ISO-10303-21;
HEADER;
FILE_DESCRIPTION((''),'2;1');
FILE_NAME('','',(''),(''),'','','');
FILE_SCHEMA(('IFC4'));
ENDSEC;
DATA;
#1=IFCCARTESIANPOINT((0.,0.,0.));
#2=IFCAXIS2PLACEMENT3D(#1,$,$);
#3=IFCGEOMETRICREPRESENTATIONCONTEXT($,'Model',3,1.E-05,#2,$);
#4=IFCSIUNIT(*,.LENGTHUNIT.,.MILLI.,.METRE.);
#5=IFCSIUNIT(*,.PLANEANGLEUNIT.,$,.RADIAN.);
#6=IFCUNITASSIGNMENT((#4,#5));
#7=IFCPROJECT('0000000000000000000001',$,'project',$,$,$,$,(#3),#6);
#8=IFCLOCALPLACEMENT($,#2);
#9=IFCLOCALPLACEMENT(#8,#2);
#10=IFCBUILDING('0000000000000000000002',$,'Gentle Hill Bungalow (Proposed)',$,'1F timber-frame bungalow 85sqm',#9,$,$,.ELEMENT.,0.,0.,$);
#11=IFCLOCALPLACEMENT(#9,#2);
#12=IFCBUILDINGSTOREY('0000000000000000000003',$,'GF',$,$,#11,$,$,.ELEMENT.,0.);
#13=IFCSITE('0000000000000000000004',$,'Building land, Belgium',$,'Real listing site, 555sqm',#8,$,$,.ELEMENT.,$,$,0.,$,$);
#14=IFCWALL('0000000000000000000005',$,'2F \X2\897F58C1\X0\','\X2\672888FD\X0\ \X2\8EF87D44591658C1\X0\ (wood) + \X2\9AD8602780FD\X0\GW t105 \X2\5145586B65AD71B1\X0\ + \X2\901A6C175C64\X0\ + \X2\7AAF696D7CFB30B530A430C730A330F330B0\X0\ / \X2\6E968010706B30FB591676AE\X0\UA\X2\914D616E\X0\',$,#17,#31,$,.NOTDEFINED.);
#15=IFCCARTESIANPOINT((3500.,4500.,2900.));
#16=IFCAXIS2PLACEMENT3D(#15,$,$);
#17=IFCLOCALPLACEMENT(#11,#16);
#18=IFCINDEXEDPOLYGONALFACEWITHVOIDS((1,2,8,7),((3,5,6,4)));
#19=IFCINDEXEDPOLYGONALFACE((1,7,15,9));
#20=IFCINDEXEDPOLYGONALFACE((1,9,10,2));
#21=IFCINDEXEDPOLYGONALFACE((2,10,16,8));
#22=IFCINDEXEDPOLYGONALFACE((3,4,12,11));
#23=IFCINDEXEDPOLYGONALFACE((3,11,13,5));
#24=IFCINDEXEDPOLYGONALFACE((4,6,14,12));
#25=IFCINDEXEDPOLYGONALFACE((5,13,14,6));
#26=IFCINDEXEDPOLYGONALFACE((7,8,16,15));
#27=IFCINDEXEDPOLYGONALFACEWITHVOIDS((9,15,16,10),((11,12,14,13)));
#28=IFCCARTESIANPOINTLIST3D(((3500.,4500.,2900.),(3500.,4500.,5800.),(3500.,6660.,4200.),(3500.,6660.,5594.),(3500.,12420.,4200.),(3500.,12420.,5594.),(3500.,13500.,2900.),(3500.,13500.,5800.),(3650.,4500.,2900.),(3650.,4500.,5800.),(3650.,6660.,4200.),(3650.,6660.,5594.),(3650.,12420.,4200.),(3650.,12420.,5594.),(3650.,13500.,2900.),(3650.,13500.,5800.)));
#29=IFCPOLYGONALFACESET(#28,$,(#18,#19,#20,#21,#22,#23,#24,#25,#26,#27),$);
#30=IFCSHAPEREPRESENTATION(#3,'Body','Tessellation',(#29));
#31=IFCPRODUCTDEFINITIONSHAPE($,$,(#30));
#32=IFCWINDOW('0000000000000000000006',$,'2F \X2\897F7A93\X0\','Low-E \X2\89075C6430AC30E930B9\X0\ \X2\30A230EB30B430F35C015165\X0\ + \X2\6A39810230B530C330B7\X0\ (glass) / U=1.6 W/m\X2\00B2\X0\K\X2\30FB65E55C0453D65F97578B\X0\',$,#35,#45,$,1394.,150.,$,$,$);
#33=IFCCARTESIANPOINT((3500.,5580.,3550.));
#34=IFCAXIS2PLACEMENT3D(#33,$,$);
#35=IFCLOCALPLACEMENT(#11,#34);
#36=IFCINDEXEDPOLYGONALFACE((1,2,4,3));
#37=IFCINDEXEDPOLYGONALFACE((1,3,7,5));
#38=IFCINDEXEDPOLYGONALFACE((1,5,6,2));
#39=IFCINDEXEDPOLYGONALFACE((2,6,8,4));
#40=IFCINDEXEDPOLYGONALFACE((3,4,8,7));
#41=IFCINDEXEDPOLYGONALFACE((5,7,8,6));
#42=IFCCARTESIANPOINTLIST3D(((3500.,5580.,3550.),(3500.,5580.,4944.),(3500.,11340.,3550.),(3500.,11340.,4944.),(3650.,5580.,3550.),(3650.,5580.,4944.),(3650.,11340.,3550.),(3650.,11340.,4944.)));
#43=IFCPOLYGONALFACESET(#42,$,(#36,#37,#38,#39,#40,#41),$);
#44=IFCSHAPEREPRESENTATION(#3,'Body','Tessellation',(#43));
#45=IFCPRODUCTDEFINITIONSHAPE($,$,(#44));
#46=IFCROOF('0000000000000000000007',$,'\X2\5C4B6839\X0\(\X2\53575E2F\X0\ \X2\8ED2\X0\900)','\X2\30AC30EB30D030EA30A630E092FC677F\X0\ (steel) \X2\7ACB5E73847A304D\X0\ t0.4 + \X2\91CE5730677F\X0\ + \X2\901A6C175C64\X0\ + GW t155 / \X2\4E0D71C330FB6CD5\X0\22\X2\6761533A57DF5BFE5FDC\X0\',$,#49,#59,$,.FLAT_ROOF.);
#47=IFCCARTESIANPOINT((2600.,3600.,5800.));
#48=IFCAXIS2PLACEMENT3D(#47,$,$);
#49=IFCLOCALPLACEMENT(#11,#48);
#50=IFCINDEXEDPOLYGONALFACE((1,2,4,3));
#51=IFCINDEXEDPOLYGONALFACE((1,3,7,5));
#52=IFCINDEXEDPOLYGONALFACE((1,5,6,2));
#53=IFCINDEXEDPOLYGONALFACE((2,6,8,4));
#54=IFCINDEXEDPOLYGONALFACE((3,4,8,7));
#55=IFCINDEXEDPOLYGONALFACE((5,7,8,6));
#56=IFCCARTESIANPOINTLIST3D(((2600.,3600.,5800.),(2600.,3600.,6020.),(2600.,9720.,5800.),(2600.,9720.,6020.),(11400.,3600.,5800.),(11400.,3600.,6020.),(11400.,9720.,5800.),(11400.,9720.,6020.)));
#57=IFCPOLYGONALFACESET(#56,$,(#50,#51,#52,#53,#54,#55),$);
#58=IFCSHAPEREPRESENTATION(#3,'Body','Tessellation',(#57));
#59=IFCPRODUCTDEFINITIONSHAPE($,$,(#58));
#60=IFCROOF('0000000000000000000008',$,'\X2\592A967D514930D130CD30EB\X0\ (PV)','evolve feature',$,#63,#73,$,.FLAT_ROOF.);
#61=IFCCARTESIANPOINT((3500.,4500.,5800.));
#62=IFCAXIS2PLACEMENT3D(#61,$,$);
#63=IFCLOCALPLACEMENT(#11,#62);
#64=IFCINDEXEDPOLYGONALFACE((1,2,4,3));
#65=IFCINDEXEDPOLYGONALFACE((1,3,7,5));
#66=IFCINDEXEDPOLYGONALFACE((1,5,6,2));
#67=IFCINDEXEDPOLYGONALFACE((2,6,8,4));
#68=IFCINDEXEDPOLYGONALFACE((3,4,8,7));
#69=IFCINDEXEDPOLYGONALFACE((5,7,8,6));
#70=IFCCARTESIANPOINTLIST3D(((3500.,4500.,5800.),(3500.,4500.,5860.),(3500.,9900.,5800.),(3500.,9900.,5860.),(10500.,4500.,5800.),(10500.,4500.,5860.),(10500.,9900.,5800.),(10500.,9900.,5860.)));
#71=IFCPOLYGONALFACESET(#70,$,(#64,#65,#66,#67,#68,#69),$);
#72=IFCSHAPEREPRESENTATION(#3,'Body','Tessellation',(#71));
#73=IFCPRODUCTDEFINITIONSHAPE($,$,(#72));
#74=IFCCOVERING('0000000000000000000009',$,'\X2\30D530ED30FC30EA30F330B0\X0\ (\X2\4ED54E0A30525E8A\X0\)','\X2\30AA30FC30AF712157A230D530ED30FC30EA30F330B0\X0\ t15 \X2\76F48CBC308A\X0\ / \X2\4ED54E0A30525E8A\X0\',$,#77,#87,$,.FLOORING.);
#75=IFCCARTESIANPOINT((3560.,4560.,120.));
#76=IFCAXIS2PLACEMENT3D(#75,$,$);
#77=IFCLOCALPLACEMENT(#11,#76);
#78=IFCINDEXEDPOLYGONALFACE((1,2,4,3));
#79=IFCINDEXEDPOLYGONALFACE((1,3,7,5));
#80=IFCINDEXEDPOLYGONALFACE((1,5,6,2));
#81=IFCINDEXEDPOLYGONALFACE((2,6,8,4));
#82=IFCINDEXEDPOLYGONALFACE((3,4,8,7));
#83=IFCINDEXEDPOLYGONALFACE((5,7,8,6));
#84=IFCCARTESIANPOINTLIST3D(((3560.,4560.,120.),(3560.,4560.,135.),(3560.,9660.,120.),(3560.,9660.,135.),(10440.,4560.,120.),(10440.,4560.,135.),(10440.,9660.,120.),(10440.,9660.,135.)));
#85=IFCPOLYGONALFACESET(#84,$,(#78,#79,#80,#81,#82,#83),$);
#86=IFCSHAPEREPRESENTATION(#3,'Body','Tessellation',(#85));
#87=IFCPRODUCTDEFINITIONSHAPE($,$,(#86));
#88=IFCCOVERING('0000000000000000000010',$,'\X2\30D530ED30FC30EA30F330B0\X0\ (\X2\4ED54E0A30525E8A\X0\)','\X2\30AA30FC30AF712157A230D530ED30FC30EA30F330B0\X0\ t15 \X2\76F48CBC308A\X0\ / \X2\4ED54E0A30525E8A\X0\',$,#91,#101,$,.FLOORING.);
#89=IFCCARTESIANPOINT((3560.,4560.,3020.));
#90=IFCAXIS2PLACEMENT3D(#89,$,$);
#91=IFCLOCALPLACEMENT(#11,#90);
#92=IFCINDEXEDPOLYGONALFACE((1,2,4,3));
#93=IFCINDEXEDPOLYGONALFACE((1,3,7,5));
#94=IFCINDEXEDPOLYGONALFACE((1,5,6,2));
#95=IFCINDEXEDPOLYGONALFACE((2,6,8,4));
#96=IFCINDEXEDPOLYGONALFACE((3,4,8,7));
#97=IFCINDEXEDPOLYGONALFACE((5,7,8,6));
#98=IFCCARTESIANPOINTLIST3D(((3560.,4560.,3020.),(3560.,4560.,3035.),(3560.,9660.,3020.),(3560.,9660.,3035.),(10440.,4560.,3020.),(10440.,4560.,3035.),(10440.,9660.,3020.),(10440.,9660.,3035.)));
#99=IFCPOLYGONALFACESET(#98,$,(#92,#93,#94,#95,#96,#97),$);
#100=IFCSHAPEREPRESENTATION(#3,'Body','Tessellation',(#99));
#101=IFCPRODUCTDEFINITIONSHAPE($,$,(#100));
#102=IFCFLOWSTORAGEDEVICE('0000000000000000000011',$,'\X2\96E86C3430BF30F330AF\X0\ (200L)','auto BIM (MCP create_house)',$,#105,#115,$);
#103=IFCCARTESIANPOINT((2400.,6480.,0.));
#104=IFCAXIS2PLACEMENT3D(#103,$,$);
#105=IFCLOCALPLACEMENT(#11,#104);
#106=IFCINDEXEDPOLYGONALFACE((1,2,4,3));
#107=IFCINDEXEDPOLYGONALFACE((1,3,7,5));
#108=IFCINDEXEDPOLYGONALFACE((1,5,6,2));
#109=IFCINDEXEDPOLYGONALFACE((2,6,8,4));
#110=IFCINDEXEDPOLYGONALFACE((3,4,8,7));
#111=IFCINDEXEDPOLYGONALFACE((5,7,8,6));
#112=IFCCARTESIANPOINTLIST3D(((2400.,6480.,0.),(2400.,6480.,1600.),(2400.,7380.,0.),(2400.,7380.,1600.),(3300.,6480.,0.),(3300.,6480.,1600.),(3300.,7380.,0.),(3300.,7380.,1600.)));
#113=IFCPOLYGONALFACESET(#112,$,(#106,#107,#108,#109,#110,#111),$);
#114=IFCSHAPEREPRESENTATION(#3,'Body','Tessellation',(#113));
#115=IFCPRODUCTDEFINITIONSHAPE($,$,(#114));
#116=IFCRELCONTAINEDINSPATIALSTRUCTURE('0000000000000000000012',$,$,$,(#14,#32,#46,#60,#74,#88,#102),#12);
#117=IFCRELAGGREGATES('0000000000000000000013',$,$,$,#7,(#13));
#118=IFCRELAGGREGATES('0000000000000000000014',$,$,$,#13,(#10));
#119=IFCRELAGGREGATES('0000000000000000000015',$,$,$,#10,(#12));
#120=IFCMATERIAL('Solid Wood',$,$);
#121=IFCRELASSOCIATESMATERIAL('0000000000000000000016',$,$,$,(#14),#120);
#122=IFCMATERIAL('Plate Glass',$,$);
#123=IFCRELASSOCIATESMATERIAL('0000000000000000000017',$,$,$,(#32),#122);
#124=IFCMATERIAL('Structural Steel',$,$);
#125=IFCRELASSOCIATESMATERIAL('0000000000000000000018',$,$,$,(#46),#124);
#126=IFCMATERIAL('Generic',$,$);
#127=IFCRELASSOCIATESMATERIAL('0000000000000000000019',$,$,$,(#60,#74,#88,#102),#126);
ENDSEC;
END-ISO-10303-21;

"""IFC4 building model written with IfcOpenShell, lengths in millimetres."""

from ifc_helpers import new_model, si_unit, frame, frame_2d, origin, place, context, project, spatial, rectangle, extrude, material, element, fill, save


model = new_model("IFC4")

# Units and contexts
model_context = context("Model", 3, precision=1e-05, world=origin())
ifc_project = project(units=[si_unit("LENGTHUNIT", "METRE", prefix="MILLI"), si_unit("PLANEANGLEUNIT", "RADIAN")], contexts=[model_context])

# Site, building, storey
site_placement = place(None, origin())
site = spatial("IfcSite", under=ifc_project, at=site_placement, Name="Building land, Belgium", ObjectType="Real listing site, 555sqm", CompositionType="ELEMENT", RefElevation=0.0)
building_placement = place(site_placement, origin())
building = spatial("IfcBuilding", under=site, at=building_placement, Name="Gentle Hill Bungalow (Proposed)", ObjectType="1F timber-frame bungalow 85sqm", CompositionType="ELEMENT", ElevationOfRefHeight=0.0, ElevationOfTerrain=0.0)
storey_placement = place(building_placement, origin())
storey = spatial("IfcBuildingStorey", under=building, at=storey_placement, Name="GF", CompositionType="ELEMENT", Elevation=0.0)

# Shared definitions
ifc_material_1 = material(Name="Solid Wood")
ifc_material_2 = material(Name="Generic")

# Shared definitions
ifc_material_3 = material(Name="Plate Glass")

# Wall, opening, window
wall_1_placement = place(storey_placement, frame((3500.0, 4500.0, 2900.0)))
wall_1 = element("IfcWall", 1, at=wall_1_placement, inside=storey, material=ifc_material_1, Name="2F 西壁", Description="木製 軸組外壁 (wood) + 高性能GW t105 充填断熱 + 通気層 + 窯業系サイディング / 準耐火・外皮UA配慮", PredefinedType="NOTDEFINED", context=model_context, shape_type="SweptSolid", body=[
    extrude(rectangle(XDim=150.0, YDim=9000.0, at=frame_2d((75.0, 4500.0))), frame((3500.0, 4500.0, 2900.0)), (0.0, 0.0, 1.0), 2900.0),
])
opening_1_placement = place(storey_placement, frame((3500.0, 5580.0, 3550.0)))
opening_1 = element("IfcOpeningElement", 2, at=opening_1_placement, cuts=wall_1, PredefinedType="NOTDEFINED", context=model_context, shape_type="SweptSolid", body=[
    extrude(rectangle(XDim=150.0, YDim=5760.0, at=frame_2d((75.0, 2880.0))), frame((3500.0, 5580.0, 3550.0)), (0.0, 0.0, 1.0), 1394.0),
])
window_1_placement = place(storey_placement, frame((3500.0, 5580.0, 3550.0)))
window_1 = element("IfcWindow", 3, at=window_1_placement, inside=storey, material=ifc_material_3, Name="2F 西窓", Description="Low-E 複層ガラス アルゴン封入 + 樹脂サッシ (glass) / U=1.6 W/m²K・日射取得型", OverallHeight=1394.0, OverallWidth=150.0, context=model_context, shape_type="SweptSolid", body=[
    extrude(rectangle(XDim=150.0, YDim=5760.0, at=frame_2d((75.0, 2880.0))), frame((3500.0, 5580.0, 3550.0)), (0.0, 0.0, 1.0), 1394.0),
])
fill(opening_1, window_1)

# Roofs
ifc_material_4 = material(Name="Structural Steel")
for number, where, name in (
    (4, (2600.0, 3600.0, 5800.0), "屋根(南帯 軒900)"),
):
    element("IfcRoof", number, at=place(storey_placement, frame(where)), inside=storey, material=ifc_material_4, Name=name, Description="ガルバリウム鋼板 (steel) 立平葺き t0.4 + 野地板 + 通気層 + GW t155 / 不燃・法22条区域対応", PredefinedType="FLAT_ROOF", context=model_context, shape_type="SweptSolid", body=[
        extrude(rectangle(XDim=8800.0, YDim=6120.0, at=frame_2d((4400.0, 3060.0))), frame((2600.0, 3600.0, 5800.0)), (0.0, 0.0, 1.0), 220.0),
    ])
roof_placement = place(storey_placement, frame((3500.0, 4500.0, 5800.0)))
element("IfcRoof", 5, at=roof_placement, inside=storey, material=ifc_material_2, Name="太陽光パネル (PV)", Description="evolve feature", PredefinedType="FLAT_ROOF", context=model_context, shape_type="SweptSolid", body=[
    extrude(rectangle(XDim=7000.0, YDim=5400.0, at=frame_2d((3500.0, 2700.0))), frame((3500.0, 4500.0, 5800.0)), (0.0, 0.0, 1.0), 60.0),
])

# Coverings
covering_1_placement = place(storey_placement, frame((3560.0, 4560.0, 120.0)))
element("IfcCovering", 6, at=covering_1_placement, inside=storey, material=ifc_material_2, Name="フローリング (仕上げ床)", Description="オーク無垢フローリング t15 直貼り / 仕上げ床", PredefinedType="FLOORING", context=model_context, shape_type="SweptSolid", body=[
    extrude(rectangle(XDim=6880.0, YDim=5100.0, at=frame_2d((3440.0, 2550.0))), frame((3560.0, 4560.0, 120.0)), (0.0, 0.0, 1.0), 15.0),
])
covering_2_placement = place(storey_placement, frame((3560.0, 4560.0, 3020.0)))
element("IfcCovering", 7, at=covering_2_placement, inside=storey, material=ifc_material_2, Name="フローリング (仕上げ床)", Description="オーク無垢フローリング t15 直貼り / 仕上げ床", PredefinedType="FLOORING", context=model_context, shape_type="SweptSolid", body=[
    extrude(rectangle(XDim=6880.0, YDim=5100.0, at=frame_2d((3440.0, 2550.0))), frame((3560.0, 4560.0, 3020.0)), (0.0, 0.0, 1.0), 15.0),
])

# Flow storage device
flow_storage_device_placement = place(storey_placement, frame((2400.0, 6480.0, 0.0)))
element("IfcFlowStorageDevice", 8, at=flow_storage_device_placement, inside=storey, material=ifc_material_2, Name="雨水タンク (200L)", Description="auto BIM (MCP create_house)", context=model_context, shape_type="SweptSolid", body=[
    extrude(rectangle(XDim=900.0, YDim=900.0, at=frame_2d((450.0, 450.0))), frame((2400.0, 6480.0, 0.0)), (0.0, 0.0, 1.0), 1600.0),
])

save(model, "model.ifc")
